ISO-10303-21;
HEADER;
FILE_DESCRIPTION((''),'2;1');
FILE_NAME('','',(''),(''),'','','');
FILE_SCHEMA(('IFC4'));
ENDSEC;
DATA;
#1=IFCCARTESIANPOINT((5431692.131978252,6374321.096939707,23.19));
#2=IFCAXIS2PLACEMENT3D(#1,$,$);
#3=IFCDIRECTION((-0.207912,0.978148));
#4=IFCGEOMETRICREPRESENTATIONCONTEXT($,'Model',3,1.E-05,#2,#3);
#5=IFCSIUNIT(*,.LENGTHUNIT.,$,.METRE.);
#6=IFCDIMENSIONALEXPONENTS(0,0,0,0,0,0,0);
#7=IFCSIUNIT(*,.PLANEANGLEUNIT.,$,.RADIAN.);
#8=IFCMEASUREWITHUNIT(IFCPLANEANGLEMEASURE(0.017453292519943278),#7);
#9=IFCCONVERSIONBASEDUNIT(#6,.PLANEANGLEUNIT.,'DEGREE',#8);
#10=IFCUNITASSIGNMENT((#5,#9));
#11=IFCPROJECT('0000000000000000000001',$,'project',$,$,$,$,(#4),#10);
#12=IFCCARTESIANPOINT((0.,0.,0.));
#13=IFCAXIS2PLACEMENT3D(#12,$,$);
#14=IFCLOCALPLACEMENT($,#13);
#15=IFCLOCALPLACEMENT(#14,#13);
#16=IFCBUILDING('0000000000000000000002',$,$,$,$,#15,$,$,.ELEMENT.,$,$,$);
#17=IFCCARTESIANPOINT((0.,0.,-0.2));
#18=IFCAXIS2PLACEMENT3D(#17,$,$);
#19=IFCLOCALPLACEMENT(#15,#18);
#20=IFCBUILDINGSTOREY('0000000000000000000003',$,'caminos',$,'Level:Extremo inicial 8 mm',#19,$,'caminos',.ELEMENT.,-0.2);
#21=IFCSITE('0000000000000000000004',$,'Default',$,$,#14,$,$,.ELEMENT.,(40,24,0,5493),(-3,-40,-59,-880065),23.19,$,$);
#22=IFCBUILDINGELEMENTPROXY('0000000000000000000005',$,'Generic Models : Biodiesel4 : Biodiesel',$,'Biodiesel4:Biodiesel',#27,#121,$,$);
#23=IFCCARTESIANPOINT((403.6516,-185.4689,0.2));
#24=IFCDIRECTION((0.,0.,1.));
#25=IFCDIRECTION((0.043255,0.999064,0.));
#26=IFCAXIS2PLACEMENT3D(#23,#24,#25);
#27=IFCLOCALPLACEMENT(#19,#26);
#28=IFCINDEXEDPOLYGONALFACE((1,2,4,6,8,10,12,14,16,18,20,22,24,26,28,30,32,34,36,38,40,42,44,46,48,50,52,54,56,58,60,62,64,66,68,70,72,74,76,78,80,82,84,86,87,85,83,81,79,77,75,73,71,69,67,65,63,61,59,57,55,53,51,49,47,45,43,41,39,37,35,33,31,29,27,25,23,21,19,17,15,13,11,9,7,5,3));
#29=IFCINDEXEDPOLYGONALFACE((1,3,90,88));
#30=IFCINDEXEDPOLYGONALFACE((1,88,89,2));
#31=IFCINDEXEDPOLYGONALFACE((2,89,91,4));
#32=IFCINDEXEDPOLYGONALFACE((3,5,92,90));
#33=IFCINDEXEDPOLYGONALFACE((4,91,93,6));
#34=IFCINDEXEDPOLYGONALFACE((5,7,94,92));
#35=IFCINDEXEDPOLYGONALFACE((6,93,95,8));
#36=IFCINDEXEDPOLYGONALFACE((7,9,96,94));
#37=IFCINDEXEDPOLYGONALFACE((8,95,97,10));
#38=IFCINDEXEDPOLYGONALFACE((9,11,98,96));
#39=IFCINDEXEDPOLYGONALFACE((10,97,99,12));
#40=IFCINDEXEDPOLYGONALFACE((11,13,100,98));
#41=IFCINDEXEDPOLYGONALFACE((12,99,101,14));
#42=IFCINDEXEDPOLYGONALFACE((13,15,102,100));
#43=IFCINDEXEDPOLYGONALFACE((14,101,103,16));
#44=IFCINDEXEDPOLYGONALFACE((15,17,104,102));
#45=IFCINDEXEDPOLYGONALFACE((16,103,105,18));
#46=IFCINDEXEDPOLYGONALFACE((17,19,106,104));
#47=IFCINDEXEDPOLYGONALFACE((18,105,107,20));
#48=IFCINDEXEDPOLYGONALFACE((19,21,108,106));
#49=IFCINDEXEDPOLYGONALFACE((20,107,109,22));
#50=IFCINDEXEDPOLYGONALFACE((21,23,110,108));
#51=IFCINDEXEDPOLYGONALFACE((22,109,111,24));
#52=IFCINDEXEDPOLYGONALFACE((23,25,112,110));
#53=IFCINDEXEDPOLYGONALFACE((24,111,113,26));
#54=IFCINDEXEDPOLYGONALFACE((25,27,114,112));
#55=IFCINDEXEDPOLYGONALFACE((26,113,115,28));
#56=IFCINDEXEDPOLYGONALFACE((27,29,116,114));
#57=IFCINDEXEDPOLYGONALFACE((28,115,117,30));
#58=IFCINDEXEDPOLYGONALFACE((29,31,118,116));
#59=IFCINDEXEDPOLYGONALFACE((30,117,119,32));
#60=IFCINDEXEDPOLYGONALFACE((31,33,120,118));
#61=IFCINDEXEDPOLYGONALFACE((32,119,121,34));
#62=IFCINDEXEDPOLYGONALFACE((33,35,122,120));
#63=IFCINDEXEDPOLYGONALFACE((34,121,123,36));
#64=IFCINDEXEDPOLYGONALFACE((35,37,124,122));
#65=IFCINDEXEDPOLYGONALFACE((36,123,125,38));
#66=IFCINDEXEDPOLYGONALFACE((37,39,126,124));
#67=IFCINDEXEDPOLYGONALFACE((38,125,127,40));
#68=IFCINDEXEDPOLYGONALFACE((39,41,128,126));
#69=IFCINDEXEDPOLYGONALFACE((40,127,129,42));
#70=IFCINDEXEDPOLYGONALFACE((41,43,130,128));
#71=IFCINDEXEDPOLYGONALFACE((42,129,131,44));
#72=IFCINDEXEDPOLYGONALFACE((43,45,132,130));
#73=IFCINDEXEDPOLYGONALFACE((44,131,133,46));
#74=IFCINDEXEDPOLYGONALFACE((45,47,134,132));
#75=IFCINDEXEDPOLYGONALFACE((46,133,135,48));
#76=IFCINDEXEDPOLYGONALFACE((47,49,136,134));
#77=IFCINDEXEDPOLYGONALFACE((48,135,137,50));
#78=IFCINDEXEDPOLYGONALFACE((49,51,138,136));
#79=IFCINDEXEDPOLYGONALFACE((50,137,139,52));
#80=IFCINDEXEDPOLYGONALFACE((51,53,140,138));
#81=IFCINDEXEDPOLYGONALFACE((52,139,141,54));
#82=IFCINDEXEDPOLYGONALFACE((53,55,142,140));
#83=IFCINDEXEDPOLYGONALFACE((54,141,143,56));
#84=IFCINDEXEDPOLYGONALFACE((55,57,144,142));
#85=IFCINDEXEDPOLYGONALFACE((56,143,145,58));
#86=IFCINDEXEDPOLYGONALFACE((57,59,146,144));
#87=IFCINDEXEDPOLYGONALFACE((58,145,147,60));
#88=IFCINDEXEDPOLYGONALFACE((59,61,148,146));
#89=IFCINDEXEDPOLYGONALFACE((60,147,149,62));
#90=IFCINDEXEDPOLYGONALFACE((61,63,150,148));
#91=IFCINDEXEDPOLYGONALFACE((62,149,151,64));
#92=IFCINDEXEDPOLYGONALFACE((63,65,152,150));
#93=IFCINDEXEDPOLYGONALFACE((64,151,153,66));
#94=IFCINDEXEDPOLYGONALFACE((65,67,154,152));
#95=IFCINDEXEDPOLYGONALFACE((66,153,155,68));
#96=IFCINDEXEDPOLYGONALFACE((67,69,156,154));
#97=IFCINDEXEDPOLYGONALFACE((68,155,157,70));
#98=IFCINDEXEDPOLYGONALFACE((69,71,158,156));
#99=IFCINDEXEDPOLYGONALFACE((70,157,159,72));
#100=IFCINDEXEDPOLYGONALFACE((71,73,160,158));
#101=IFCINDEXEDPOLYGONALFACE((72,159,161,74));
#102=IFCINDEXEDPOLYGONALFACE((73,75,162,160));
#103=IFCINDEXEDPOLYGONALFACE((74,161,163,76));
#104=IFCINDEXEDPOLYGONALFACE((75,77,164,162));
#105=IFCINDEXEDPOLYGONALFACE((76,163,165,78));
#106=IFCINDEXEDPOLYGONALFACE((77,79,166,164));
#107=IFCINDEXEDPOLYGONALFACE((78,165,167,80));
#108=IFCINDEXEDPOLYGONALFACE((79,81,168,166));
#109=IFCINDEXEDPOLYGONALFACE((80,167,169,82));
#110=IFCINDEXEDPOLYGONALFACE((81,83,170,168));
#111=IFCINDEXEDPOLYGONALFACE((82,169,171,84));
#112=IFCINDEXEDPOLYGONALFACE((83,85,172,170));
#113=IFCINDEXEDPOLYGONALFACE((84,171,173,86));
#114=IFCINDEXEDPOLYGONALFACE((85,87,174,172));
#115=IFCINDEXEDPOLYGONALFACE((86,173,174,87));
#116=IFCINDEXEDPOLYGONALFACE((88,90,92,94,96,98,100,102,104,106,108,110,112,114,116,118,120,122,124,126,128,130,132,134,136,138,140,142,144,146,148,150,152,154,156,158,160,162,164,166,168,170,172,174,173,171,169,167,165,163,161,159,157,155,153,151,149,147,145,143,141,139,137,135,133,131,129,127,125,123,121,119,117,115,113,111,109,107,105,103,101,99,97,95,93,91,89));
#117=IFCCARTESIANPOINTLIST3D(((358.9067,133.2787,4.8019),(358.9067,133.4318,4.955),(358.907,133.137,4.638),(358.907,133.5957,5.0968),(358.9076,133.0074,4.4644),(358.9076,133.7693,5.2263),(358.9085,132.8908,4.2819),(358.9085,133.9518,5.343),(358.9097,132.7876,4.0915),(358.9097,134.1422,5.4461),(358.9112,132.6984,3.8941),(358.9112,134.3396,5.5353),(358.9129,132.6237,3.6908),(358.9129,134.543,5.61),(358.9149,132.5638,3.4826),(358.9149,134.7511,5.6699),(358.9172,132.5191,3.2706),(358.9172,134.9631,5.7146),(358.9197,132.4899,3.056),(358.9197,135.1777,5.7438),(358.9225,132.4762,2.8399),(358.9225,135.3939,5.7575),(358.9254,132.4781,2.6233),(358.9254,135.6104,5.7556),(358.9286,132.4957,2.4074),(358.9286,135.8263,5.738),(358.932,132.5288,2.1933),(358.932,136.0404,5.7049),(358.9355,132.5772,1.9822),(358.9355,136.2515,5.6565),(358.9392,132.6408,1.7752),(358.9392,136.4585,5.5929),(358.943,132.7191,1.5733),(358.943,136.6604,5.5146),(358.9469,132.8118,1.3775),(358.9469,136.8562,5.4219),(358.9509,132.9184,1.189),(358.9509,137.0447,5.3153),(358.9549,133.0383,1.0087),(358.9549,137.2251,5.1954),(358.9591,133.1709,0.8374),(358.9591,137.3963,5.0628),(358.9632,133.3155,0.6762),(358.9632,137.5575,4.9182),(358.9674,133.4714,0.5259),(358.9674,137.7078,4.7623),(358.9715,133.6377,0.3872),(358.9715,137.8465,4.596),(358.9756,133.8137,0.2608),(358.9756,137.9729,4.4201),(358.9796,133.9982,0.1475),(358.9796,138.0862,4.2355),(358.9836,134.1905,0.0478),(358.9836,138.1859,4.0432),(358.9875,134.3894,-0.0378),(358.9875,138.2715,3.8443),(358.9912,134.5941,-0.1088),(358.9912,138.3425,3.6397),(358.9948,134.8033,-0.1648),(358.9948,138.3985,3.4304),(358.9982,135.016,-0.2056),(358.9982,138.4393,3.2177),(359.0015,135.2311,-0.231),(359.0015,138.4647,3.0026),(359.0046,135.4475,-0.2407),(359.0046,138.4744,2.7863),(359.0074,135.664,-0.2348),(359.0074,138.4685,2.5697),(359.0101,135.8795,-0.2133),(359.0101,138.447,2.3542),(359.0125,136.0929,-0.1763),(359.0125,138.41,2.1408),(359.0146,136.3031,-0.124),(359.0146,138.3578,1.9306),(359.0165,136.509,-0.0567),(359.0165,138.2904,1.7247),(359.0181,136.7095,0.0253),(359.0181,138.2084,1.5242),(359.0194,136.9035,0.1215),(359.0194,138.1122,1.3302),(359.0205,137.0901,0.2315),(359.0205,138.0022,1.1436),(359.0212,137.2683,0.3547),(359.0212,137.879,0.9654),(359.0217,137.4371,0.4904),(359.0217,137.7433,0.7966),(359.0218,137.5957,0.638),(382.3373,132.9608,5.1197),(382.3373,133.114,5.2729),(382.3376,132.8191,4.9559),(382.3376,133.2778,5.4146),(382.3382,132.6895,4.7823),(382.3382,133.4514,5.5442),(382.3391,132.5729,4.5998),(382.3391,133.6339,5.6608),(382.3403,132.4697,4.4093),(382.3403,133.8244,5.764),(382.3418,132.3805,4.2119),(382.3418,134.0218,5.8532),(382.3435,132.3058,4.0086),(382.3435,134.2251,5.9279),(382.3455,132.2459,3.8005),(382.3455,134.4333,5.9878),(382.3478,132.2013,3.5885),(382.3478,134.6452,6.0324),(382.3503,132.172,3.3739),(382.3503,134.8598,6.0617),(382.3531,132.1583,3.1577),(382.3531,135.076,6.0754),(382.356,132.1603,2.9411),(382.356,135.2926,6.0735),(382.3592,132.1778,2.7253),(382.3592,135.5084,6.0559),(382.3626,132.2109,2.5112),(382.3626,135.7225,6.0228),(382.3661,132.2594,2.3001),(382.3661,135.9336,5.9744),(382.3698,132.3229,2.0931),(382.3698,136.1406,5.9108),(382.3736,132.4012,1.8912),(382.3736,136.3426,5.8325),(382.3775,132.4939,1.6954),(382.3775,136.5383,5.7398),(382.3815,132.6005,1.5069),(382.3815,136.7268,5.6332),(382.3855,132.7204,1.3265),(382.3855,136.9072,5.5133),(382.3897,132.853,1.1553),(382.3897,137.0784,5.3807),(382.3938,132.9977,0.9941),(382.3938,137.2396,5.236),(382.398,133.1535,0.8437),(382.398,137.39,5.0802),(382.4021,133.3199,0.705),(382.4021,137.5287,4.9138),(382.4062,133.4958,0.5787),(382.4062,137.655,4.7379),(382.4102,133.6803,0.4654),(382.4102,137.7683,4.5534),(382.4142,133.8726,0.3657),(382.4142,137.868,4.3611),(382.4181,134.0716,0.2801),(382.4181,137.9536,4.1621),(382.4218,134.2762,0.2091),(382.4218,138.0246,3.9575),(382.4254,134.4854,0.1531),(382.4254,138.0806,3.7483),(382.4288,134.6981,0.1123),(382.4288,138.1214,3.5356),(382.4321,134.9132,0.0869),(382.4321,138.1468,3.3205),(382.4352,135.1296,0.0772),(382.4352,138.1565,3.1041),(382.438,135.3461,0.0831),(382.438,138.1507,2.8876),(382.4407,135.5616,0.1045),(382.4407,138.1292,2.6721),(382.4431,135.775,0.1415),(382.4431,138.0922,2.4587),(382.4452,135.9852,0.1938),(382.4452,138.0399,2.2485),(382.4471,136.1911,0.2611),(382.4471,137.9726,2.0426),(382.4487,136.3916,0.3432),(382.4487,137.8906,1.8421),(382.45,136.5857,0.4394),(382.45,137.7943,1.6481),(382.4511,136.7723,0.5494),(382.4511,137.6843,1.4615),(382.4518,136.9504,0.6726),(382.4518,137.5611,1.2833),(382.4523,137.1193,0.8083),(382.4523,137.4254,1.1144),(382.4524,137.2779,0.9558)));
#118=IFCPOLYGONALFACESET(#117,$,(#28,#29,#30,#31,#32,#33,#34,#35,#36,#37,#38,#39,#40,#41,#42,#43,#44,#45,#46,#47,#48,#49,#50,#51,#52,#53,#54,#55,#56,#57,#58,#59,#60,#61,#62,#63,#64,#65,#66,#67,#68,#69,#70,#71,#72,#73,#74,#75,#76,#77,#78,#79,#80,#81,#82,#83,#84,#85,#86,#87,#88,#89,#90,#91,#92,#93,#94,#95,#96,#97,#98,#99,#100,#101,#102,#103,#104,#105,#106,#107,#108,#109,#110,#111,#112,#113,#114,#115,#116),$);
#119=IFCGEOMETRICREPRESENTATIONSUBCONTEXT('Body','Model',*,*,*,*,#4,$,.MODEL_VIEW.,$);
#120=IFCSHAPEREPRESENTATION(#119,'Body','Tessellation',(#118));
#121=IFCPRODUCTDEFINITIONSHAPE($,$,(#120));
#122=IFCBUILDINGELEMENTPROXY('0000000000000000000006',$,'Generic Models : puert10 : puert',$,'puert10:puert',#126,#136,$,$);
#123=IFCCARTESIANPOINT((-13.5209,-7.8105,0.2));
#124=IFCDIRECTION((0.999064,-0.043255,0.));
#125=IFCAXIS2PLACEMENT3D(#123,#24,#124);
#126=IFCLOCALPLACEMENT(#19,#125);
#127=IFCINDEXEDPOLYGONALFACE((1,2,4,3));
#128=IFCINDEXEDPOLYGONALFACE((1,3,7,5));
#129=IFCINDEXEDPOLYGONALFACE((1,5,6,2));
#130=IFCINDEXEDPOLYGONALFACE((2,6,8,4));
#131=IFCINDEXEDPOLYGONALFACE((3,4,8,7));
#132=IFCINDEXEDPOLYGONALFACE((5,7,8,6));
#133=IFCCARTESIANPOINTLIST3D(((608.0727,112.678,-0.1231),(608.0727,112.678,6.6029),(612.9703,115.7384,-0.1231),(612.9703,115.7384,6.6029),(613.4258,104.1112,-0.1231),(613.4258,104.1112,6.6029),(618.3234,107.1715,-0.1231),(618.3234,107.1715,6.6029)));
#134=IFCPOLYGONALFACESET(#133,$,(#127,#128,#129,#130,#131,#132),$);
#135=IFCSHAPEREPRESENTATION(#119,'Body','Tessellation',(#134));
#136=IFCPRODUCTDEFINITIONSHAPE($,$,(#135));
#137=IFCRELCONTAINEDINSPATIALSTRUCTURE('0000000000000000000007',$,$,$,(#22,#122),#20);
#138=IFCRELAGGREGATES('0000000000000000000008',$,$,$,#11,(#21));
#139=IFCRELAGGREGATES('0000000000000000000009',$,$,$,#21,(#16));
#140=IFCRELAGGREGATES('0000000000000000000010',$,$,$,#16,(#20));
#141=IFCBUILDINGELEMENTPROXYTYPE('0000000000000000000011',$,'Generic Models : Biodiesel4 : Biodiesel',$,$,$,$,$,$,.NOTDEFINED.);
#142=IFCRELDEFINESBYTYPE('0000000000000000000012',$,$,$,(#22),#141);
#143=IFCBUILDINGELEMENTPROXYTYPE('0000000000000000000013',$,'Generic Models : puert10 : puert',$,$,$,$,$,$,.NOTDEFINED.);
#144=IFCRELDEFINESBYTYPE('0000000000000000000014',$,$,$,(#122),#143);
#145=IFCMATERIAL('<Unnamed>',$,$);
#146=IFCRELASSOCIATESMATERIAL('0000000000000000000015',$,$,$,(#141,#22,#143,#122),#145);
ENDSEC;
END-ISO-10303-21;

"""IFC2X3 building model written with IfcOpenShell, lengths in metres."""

from ifc_helpers import new_model, entity, si_unit, converted_unit, direction, frame, frame_2d, origin, place, context, subcontext, project, spatial, rectangle, circle, extrude, source, transform, mapped, material, type_object, type_shapes, element, save


model = new_model("IFC2X3")

# Units and contexts
model_context = context("Model", 3, precision=1e-05, world=frame((5431692.131978252, 6374321.096939707, 23.19)), true_north=direction((-0.207912, 0.978148)))
body_context = subcontext(model_context, "Body", "Model", "MODEL_VIEW")
ifc_project = project(units=[si_unit("LENGTHUNIT", "METRE"), converted_unit("PLANEANGLEUNIT", "DEGREE", entity("IfcPlaneAngleMeasure", 0.017453292519943278), si_unit("PLANEANGLEUNIT", "RADIAN"), dimensions=[0, 0, 0, 0, 0, 0, 0])], contexts=[model_context])

# Site, building, storey
site_placement = place(None, origin())
site = spatial("IfcSite", under=ifc_project, at=site_placement, Name="Default", CompositionType="ELEMENT", RefLatitude=(40, 24, 0, 5493), RefLongitude=(-3, -40, -59, -880065), RefElevation=23.19)
building_placement = place(site_placement, origin())
building = spatial("IfcBuilding", under=site, at=building_placement, CompositionType="ELEMENT")
storey_placement = place(building_placement, frame((0.0, 0.0, -0.2)))
storey = spatial("IfcBuildingStorey", under=building, at=storey_placement, Name="caminos", ObjectType="Level:Extremo inicial 8 mm", LongName="caminos", CompositionType="ELEMENT", Elevation=-0.2)

# Building element proxies
ifc_material_1 = material(Name="<Unnamed>")
building_element_proxy_type_1 = type_object("IfcBuildingElementProxyType", Name="Generic Models : Biodiesel4 : Biodiesel", PredefinedType="NOTDEFINED", material=ifc_material_1)
shared_shape_1 = source(origin(), body_context, "Body", "SweptSolid", [
    extrude(circle(Radius=3.0, at=frame_2d((0.0, 0.0), x_axis=(1.0, 0.0))), frame((382.3949, 135.1569, 3.0768), z_axis=(-0.999816, 0.013564, -0.013564), x_axis=(0.019183, 0.706977, -0.706977)), (0.0, 0.0, 1.0), 23.4349),
])
type_shapes(building_element_proxy_type_1, [shared_shape_1])
proxy_1_placement = place(storey_placement, frame((403.6516, -185.4689, 0.2), z_axis=(0.0, 0.0, 1.0), x_axis=(0.043255, 0.999064, 0.0)))
element("IfcBuildingElementProxy", 1, at=proxy_1_placement, inside=storey, type_object=building_element_proxy_type_1, material=ifc_material_1, Name="Generic Models : Biodiesel4 : Biodiesel", ObjectType="Biodiesel4:Biodiesel", context=body_context, shape_type="MappedRepresentation", body=[
    mapped(shared_shape_1, transform((0.0, 0.0, 0.0), scale=1.0)),
])
building_element_proxy_type_2 = type_object("IfcBuildingElementProxyType", Name="Generic Models : puert10 : puert", PredefinedType="NOTDEFINED", material=ifc_material_1)
shared_shape_2 = source(origin(), body_context, "Body", "SweptSolid", [
    extrude(rectangle(XDim=5.7752, YDim=10.1018, at=frame_2d((0.0, 0.0), x_axis=(1.0, 0.0))), frame((613.198, 109.9248, -0.1231), z_axis=(0.0, 0.0, 1.0), x_axis=(-0.848048, -0.529919, 0.0)), (0.0, 0.0, 1.0), 6.726),
])
type_shapes(building_element_proxy_type_2, [shared_shape_2])
proxy_2_placement = place(storey_placement, frame((-13.5209, -7.8105, 0.2), z_axis=(0.0, 0.0, 1.0), x_axis=(0.999064, -0.043255, 0.0)))
element("IfcBuildingElementProxy", 2, at=proxy_2_placement, inside=storey, type_object=building_element_proxy_type_2, material=ifc_material_1, Name="Generic Models : puert10 : puert", ObjectType="puert10:puert", context=body_context, shape_type="MappedRepresentation", body=[
    mapped(shared_shape_2, transform((0.0, 0.0, 0.0), scale=1.0)),
])

save(model, "model.ifc")
